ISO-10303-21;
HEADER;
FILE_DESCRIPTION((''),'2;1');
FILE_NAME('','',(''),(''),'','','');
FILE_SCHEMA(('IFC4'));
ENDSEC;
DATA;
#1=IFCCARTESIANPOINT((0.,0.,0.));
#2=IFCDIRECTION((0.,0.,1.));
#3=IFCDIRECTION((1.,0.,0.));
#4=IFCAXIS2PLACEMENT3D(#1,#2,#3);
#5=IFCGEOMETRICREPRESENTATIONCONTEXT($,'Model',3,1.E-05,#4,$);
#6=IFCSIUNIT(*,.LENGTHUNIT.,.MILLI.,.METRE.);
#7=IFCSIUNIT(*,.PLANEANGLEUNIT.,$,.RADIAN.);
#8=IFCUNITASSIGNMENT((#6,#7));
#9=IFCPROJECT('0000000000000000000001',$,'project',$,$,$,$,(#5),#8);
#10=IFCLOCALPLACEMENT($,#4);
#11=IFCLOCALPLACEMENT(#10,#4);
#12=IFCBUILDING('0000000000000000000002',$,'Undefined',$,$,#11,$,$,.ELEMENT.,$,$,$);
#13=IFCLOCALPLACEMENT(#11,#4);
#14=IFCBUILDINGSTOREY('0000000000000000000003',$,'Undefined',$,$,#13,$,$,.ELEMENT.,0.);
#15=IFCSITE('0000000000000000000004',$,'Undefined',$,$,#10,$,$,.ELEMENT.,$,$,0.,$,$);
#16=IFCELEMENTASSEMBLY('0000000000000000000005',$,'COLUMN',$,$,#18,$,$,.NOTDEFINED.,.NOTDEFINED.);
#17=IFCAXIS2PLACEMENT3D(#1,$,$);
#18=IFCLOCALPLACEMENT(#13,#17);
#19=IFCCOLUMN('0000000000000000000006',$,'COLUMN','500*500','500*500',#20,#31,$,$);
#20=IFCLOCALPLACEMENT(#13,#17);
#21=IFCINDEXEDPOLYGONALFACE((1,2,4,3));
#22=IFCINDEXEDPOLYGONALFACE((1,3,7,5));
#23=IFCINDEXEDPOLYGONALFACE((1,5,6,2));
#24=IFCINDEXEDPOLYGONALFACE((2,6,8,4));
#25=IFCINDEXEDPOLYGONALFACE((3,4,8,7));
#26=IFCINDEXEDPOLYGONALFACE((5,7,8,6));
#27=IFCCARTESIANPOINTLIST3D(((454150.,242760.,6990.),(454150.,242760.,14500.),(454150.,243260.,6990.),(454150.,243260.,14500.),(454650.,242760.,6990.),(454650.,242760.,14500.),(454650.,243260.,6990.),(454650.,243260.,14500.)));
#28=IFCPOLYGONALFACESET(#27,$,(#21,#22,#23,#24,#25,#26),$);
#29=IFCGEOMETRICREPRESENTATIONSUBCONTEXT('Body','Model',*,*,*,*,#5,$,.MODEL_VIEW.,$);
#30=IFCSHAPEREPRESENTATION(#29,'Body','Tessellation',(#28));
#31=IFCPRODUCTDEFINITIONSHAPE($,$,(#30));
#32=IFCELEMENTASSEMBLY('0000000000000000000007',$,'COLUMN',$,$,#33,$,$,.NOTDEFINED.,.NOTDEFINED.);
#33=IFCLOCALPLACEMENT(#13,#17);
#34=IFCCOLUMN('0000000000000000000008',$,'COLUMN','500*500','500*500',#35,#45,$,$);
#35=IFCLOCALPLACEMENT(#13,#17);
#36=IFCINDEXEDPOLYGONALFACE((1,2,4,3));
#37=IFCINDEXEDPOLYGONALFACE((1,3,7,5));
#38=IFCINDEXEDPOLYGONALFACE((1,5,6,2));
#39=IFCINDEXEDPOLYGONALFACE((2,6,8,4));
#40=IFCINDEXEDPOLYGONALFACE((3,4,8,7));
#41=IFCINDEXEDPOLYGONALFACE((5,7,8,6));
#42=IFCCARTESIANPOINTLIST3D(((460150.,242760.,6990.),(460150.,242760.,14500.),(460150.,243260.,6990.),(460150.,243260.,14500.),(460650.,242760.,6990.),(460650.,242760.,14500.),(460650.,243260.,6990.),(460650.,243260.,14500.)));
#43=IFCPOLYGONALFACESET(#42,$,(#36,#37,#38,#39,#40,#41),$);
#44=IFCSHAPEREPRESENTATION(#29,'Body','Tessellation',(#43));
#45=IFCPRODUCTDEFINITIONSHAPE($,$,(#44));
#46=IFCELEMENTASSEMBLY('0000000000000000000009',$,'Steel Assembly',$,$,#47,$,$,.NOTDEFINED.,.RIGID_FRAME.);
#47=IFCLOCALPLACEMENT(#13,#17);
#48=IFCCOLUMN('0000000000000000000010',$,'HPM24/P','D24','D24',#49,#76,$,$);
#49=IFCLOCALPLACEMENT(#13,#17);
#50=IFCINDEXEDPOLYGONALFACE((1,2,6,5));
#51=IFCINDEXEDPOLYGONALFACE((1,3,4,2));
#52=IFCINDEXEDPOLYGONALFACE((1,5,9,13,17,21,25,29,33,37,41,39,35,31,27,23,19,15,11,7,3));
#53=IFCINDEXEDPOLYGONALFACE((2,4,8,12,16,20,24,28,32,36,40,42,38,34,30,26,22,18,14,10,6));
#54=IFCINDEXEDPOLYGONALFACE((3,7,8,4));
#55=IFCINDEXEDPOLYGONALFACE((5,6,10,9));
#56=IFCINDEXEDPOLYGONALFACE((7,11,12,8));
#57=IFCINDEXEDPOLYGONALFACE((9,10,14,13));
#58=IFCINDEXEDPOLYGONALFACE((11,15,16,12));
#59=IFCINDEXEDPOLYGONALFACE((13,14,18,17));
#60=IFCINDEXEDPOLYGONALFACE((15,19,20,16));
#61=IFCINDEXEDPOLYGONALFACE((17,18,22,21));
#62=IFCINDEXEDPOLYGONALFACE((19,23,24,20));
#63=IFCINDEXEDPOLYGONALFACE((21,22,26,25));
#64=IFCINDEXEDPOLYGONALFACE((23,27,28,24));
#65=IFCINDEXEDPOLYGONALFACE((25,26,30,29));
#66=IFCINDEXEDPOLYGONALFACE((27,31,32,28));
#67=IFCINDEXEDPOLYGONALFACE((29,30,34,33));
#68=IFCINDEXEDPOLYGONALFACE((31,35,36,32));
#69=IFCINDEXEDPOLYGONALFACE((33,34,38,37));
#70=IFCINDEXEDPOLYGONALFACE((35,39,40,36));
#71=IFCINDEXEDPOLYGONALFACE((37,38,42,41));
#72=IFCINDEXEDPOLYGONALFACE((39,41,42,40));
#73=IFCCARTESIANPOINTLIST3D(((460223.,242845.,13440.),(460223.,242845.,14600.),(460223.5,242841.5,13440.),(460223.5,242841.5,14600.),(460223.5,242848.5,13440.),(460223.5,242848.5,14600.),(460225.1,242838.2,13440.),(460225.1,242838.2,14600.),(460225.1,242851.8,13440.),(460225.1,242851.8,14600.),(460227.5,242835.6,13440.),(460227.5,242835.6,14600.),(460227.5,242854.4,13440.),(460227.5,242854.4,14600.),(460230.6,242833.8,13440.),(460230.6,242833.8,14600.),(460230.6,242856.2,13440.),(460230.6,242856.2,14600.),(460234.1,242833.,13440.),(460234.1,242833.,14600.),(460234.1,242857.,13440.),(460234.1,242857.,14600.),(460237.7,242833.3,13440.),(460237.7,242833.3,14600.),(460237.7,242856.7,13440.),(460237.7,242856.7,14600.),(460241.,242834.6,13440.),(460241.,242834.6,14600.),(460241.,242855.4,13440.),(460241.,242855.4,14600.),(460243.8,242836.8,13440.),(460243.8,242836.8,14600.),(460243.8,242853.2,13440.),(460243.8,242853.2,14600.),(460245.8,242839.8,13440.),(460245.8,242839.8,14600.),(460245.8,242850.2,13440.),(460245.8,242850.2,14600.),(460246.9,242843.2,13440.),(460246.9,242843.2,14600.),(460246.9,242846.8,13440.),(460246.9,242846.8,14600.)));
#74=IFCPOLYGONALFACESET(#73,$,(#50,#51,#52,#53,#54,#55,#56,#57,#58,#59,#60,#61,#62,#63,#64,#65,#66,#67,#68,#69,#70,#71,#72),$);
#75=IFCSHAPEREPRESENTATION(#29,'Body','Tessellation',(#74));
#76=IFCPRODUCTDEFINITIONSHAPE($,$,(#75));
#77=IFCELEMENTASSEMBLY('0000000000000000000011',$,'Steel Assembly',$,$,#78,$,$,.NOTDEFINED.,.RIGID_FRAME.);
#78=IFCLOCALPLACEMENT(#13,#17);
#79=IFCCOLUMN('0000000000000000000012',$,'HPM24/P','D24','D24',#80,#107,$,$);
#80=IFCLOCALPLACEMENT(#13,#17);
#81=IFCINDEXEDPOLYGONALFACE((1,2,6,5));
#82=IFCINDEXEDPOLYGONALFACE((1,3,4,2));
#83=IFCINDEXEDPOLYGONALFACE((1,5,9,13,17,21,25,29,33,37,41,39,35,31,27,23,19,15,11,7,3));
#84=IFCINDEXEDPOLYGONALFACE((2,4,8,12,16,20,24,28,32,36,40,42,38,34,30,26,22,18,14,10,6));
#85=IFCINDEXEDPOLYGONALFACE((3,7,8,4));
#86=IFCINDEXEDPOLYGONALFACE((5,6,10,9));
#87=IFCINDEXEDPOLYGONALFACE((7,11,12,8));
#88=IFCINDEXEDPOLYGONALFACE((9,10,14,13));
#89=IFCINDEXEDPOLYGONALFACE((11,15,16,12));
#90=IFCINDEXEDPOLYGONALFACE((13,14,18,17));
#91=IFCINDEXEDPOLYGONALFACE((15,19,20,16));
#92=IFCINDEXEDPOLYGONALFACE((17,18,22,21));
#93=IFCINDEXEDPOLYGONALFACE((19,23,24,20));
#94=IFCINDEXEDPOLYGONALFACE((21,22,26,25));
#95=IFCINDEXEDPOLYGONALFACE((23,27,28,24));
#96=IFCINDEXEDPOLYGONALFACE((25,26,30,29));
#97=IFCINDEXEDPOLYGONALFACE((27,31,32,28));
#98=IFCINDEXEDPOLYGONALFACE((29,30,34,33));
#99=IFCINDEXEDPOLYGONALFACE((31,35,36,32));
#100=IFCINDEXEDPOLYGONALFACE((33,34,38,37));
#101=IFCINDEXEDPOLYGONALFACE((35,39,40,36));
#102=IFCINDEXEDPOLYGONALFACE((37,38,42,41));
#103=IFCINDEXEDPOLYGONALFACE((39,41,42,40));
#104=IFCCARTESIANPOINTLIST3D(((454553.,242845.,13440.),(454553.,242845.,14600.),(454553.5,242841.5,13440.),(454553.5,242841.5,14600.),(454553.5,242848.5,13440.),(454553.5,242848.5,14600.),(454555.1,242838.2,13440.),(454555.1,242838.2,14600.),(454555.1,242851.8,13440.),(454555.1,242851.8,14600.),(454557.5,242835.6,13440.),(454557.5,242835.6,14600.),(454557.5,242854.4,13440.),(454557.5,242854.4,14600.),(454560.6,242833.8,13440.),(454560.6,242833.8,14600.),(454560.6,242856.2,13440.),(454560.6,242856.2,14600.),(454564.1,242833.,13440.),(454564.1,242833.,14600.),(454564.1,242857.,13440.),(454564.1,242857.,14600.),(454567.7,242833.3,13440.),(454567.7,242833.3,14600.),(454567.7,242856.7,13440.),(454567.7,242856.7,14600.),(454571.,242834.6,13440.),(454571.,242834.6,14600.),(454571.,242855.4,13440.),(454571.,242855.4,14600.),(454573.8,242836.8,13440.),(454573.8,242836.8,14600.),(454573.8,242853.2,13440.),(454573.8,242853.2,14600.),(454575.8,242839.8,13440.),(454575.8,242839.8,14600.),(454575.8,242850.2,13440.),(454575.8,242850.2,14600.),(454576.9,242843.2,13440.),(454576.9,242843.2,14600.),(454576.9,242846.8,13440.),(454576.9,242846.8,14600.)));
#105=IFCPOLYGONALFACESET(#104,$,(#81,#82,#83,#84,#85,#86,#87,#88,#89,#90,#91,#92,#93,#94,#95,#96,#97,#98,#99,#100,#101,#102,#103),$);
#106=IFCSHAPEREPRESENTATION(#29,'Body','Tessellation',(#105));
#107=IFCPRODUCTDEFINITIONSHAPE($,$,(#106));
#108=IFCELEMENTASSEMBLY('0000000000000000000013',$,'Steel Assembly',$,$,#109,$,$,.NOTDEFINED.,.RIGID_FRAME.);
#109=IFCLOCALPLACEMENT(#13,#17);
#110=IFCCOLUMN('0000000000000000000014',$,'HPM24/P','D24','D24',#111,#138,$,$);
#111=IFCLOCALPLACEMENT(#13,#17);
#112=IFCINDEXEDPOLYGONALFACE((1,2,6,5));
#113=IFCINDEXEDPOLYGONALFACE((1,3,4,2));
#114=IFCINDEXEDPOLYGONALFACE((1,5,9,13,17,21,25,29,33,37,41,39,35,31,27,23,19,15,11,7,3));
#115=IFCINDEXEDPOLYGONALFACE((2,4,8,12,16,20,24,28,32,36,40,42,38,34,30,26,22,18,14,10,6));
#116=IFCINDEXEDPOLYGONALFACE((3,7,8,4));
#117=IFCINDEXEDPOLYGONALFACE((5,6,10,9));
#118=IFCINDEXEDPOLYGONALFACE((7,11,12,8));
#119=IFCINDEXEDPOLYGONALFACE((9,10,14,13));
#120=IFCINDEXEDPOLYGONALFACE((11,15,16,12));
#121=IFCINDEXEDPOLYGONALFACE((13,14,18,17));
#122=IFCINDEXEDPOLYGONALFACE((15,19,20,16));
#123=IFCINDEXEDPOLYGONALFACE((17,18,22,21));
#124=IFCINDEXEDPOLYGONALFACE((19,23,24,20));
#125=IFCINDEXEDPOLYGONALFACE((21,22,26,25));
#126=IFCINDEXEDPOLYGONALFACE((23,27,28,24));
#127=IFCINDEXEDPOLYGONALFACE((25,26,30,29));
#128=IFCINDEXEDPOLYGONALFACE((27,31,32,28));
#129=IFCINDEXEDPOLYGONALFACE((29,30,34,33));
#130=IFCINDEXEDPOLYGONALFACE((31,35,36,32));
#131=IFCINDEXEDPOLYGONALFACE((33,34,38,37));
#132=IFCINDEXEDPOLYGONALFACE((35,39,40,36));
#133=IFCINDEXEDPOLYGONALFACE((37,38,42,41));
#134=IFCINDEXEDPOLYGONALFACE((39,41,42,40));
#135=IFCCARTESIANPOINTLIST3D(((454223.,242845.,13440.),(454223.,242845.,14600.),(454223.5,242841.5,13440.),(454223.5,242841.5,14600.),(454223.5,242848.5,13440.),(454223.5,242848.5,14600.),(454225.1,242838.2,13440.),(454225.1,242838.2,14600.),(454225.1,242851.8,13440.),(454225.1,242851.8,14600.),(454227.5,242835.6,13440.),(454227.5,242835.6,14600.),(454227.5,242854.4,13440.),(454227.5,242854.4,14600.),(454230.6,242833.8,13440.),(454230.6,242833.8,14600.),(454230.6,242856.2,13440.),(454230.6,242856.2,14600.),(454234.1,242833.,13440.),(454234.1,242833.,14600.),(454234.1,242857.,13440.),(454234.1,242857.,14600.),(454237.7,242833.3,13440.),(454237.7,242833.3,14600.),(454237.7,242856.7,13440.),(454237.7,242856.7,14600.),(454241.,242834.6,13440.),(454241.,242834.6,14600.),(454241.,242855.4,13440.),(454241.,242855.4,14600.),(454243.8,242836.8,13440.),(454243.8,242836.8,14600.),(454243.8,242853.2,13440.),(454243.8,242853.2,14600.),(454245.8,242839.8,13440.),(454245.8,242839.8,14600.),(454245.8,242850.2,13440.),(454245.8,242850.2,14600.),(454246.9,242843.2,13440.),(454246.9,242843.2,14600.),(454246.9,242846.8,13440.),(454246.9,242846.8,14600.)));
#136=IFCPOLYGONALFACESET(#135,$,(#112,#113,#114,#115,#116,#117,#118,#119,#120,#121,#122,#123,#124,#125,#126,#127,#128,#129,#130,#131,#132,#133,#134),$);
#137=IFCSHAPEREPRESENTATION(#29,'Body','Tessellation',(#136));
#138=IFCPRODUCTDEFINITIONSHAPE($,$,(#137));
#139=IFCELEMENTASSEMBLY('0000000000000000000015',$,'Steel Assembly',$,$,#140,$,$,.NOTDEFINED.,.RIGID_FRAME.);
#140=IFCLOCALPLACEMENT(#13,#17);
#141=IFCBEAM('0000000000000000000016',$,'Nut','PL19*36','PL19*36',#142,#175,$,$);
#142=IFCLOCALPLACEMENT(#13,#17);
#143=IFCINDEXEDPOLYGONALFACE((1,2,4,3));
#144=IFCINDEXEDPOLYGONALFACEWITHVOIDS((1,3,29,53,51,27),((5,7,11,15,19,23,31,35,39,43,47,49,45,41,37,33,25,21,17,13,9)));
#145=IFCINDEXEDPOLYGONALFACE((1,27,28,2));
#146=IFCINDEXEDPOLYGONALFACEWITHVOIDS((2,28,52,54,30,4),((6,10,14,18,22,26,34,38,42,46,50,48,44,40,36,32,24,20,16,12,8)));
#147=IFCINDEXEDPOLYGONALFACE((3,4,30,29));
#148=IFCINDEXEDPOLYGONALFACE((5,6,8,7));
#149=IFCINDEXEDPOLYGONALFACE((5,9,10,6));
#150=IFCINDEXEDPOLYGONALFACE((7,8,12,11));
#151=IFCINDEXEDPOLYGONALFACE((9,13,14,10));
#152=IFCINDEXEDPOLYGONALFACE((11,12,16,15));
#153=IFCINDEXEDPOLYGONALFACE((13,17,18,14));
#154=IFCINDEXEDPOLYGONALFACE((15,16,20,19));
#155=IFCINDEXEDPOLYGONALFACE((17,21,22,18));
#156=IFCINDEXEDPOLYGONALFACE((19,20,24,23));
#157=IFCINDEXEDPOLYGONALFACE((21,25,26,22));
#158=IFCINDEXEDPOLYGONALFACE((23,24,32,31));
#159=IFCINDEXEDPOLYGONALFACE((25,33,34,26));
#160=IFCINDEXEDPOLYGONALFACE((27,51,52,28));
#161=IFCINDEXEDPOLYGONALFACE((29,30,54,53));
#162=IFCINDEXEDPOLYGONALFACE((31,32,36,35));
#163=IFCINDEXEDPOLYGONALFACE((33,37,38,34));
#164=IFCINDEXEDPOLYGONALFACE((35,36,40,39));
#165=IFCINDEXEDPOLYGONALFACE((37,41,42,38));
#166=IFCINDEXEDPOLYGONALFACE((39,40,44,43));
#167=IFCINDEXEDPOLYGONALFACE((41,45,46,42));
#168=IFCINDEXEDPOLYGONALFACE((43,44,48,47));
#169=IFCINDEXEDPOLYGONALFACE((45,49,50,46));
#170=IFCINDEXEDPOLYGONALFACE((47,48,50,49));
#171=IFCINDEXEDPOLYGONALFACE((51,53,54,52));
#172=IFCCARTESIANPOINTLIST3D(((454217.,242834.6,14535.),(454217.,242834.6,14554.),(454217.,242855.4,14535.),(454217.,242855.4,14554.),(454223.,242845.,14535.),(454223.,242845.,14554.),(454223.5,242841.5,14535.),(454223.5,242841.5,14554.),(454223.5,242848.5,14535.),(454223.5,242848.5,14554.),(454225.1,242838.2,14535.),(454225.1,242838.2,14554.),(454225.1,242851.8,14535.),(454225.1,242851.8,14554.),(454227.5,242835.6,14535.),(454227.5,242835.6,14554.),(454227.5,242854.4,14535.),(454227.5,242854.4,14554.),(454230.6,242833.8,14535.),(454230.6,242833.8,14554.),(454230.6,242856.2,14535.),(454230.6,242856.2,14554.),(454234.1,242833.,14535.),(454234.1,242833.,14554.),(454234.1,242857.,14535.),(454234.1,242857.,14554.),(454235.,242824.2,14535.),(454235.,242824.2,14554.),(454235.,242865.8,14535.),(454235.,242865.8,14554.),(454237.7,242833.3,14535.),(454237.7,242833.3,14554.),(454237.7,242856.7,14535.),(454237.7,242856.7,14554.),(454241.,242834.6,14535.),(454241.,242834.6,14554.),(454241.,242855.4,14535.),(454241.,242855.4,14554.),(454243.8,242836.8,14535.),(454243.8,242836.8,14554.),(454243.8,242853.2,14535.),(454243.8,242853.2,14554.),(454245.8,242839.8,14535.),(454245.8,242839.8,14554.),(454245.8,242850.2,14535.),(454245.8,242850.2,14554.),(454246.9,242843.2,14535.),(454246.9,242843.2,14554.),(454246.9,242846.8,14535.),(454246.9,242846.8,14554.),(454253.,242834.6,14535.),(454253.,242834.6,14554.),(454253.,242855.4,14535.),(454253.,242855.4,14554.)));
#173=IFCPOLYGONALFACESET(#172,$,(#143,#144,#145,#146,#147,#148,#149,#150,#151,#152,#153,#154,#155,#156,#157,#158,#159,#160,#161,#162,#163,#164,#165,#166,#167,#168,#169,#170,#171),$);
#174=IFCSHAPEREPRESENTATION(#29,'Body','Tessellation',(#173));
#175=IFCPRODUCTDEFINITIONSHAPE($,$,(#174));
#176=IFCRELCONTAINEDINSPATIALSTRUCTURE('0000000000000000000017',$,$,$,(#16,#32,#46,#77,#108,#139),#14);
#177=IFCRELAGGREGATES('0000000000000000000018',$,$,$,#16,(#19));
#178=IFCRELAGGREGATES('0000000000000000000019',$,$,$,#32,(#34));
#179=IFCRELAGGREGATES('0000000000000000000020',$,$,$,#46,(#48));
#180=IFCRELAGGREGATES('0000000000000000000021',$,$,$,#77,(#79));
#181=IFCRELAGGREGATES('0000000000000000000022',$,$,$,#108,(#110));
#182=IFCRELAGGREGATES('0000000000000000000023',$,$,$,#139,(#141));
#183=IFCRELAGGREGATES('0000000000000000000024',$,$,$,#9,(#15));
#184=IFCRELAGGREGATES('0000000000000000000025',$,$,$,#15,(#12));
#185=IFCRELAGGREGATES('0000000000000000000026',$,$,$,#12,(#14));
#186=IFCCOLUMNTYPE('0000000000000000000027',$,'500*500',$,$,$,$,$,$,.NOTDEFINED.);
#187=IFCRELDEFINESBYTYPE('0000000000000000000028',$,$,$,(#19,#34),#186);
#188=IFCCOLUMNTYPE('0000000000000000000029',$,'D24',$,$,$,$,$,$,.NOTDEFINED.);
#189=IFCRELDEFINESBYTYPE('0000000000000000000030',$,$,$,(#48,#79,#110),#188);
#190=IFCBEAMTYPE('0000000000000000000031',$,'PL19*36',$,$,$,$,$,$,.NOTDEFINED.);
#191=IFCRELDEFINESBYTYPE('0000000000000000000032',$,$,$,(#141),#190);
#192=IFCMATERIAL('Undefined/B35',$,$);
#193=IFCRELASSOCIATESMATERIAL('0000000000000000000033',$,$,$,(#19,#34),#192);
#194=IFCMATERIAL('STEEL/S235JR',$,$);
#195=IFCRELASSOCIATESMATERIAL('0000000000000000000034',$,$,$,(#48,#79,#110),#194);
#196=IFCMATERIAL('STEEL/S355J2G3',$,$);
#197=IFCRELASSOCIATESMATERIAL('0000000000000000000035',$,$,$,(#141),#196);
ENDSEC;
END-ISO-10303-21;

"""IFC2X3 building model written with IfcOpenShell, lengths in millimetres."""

from ifc_helpers import new_model, si_unit, frame, origin_with_axes, origin_2d_with_axis, place, context, subcontext, project, spatial, rectangle, circle, extrude, boolean, halfspace, material, type_object, element, aggregate, save


model = new_model("IFC2X3")

# Units and contexts
model_context = context("Model", 3, precision=1e-05, world=origin_with_axes())
body_context = subcontext(model_context, "Body", "Model", "MODEL_VIEW")
ifc_project = project(units=[si_unit("LENGTHUNIT", "METRE", prefix="MILLI"), si_unit("PLANEANGLEUNIT", "RADIAN")], contexts=[model_context])

# Site, building, storey
site_placement = place(None, origin_with_axes())
site = spatial("IfcSite", under=ifc_project, at=site_placement, Name="Undefined", CompositionType="ELEMENT", RefElevation=0.0)
building_placement = place(site_placement, origin_with_axes())
building = spatial("IfcBuilding", under=site, at=building_placement, Name="Undefined", CompositionType="ELEMENT")
storey_placement = place(building_placement, origin_with_axes())
storey = spatial("IfcBuildingStorey", under=building, at=storey_placement, Name="Undefined", CompositionType="ELEMENT", Elevation=0.0)

# Element assemblies, columns
assembly_1_placement = place(storey_placement, origin_with_axes())
assembly_1 = element("IfcElementAssembly", 1, at=assembly_1_placement, inside=storey, Name="COLUMN", AssemblyPlace="NOTDEFINED", PredefinedType="NOTDEFINED")
ifc_material_1 = material(Name="Undefined/B35")
column_type_1 = type_object("IfcColumnType", Name="500*500", PredefinedType="NOTDEFINED")
column_1_placement = place(assembly_1_placement, frame((454400.0, 243010.0, 6990.0), z_axis=(0.0, 0.0, 1.0), x_axis=(1.0, 0.0, 0.0)))
column_1 = element("IfcColumn", 2, at=column_1_placement, type_object=column_type_1, material=ifc_material_1, Name="COLUMN", Description="500*500", ObjectType="500*500", context=body_context, shape_type="SweptSolid", body=[
    extrude(rectangle(XDim=500.0, YDim=500.0, at=origin_2d_with_axis()), frame((0.0, 0.0, 7510.0), z_axis=(0.0, 0.0, -1.0), x_axis=(-1.0, 0.0, 0.0)), (0.0, 0.0, 1.0), 7510.0),
])
aggregate(assembly_1, [column_1])
assembly_2_placement = place(storey_placement, origin_with_axes())
assembly_2 = element("IfcElementAssembly", 3, at=assembly_2_placement, inside=storey, Name="COLUMN", AssemblyPlace="NOTDEFINED", PredefinedType="NOTDEFINED")
column_2_placement = place(assembly_2_placement, frame((460400.0, 243010.0, 6990.0), z_axis=(0.0, 0.0, 1.0), x_axis=(1.0, 0.0, 0.0)))
column_2 = element("IfcColumn", 4, at=column_2_placement, type_object=column_type_1, material=ifc_material_1, Name="COLUMN", Description="500*500", ObjectType="500*500", context=body_context, shape_type="SweptSolid", body=[
    extrude(rectangle(XDim=500.0, YDim=500.0, at=origin_2d_with_axis()), frame((0.0, 0.0, 7510.0), z_axis=(0.0, 0.0, -1.0), x_axis=(-1.0, 0.0, 0.0)), (0.0, 0.0, 1.0), 7510.0),
])
aggregate(assembly_2, [column_2])
assembly_3_placement = place(storey_placement, origin_with_axes())
assembly_3 = element("IfcElementAssembly", 5, at=assembly_3_placement, inside=storey, Name="Steel Assembly", AssemblyPlace="NOTDEFINED", PredefinedType="RIGID_FRAME")
ifc_material_2 = material(Name="STEEL/S235JR")
column_type_2 = type_object("IfcColumnType", Name="D24", PredefinedType="NOTDEFINED")
column_3_placement = place(assembly_3_placement, frame((460235.0, 242845.0, 13440.0), z_axis=(0.0, 0.0, 1.0), x_axis=(1.0, 0.0, 0.0)))
column_3 = element("IfcColumn", 6, at=column_3_placement, type_object=column_type_2, material=ifc_material_2, Name="HPM24/P", Description="D24", ObjectType="D24", context=body_context, shape_type="SweptSolid", body=[
    extrude(circle(Radius=12.0, at=origin_2d_with_axis()), frame((0.0, 0.0, 1160.0), z_axis=(0.0, 0.0, -1.0), x_axis=(-1.0, 0.0, 0.0)), (0.0, 0.0, 1.0), 1160.0),
])
aggregate(assembly_3, [column_3])
assembly_4_placement = place(storey_placement, origin_with_axes())
assembly_4 = element("IfcElementAssembly", 7, at=assembly_4_placement, inside=storey, Name="Steel Assembly", AssemblyPlace="NOTDEFINED", PredefinedType="RIGID_FRAME")
column_4_placement = place(assembly_4_placement, frame((454565.0, 242845.0, 13440.0), z_axis=(0.0, 0.0, 1.0), x_axis=(1.0, 0.0, 0.0)))
column_4 = element("IfcColumn", 8, at=column_4_placement, type_object=column_type_2, material=ifc_material_2, Name="HPM24/P", Description="D24", ObjectType="D24", context=body_context, shape_type="SweptSolid", body=[
    extrude(circle(Radius=12.0, at=origin_2d_with_axis()), frame((0.0, 0.0, 1160.0), z_axis=(0.0, 0.0, -1.0), x_axis=(-1.0, 0.0, 0.0)), (0.0, 0.0, 1.0), 1160.0),
])
aggregate(assembly_4, [column_4])
assembly_5_placement = place(storey_placement, origin_with_axes())
assembly_5 = element("IfcElementAssembly", 9, at=assembly_5_placement, inside=storey, Name="Steel Assembly", AssemblyPlace="NOTDEFINED", PredefinedType="RIGID_FRAME")
column_5_placement = place(assembly_5_placement, frame((454235.0, 242845.0, 13440.0), z_axis=(0.0, 0.0, 1.0), x_axis=(1.0, 0.0, 0.0)))
column_5 = element("IfcColumn", 10, at=column_5_placement, type_object=column_type_2, material=ifc_material_2, Name="HPM24/P", Description="D24", ObjectType="D24", context=body_context, shape_type="SweptSolid", body=[
    extrude(circle(Radius=12.0, at=origin_2d_with_axis()), frame((0.0, 0.0, 1160.0), z_axis=(0.0, 0.0, -1.0), x_axis=(-1.0, 0.0, 0.0)), (0.0, 0.0, 1.0), 1160.0),
])
aggregate(assembly_5, [column_5])

# Element assembly, beam
assembly_6_placement = place(storey_placement, origin_with_axes())
assembly_6 = element("IfcElementAssembly", 11, at=assembly_6_placement, inside=storey, Name="Steel Assembly", AssemblyPlace="NOTDEFINED", PredefinedType="RIGID_FRAME")
ifc_material_3 = material(Name="STEEL/S355J2G3")
beam_type_1 = type_object("IfcBeamType", Name="PL19*36", PredefinedType="NOTDEFINED")
beam_1_placement = place(assembly_6_placement, frame((454235.0, 242865.8, 14544.5), z_axis=(-1.0, 0.0, 0.0), x_axis=(0.0, -1.0, 0.0)))
beam_1 = element("IfcBeam", 12, at=beam_1_placement, type_object=beam_type_1, material=ifc_material_3, Name="Nut", Description="PL19*36", ObjectType="PL19*36", context=body_context, shape_type="CSG", body=[
    boolean("DIFFERENCE", boolean("DIFFERENCE", boolean("DIFFERENCE", boolean("DIFFERENCE", boolean("DIFFERENCE", extrude(rectangle(XDim=19.0, YDim=36.0, at=origin_2d_with_axis()), frame((41.6, 0.0, 0.0), z_axis=(-1.0, 0.0, 0.0), x_axis=(0.0, -1.0, 0.0)), (0.0, 0.0, 1.0), 41.6), extrude(circle(Radius=12.0, at=origin_2d_with_axis()), frame((20.8, -9.5, 0.0), z_axis=(0.0, 1.0, 0.0), x_axis=(0.0, 0.0, 1.0)), (0.0, 0.0, 1.0), 19.0)), halfspace(frame((31.2, -9.5, -18.0), z_axis=(0.865865, 0.0, -0.500278), x_axis=(0.500278, 0.0, 0.865865)), False)), halfspace(frame((52.0, -9.5, -18.0), z_axis=(0.865865, 0.0, 0.500278), x_axis=(-0.500278, 0.0, 0.865865)), False)), halfspace(frame((-10.4, 9.5, -18.0), z_axis=(-0.865865, 0.0, 0.500278), x_axis=(0.500278, 0.0, 0.865865)), False)), halfspace(frame((10.4, 9.5, -18.0), z_axis=(-0.865865, 0.0, -0.500278), x_axis=(-0.500278, 0.0, 0.865865)), False)),
])
aggregate(assembly_6, [beam_1])

save(model, "model.ifc")
